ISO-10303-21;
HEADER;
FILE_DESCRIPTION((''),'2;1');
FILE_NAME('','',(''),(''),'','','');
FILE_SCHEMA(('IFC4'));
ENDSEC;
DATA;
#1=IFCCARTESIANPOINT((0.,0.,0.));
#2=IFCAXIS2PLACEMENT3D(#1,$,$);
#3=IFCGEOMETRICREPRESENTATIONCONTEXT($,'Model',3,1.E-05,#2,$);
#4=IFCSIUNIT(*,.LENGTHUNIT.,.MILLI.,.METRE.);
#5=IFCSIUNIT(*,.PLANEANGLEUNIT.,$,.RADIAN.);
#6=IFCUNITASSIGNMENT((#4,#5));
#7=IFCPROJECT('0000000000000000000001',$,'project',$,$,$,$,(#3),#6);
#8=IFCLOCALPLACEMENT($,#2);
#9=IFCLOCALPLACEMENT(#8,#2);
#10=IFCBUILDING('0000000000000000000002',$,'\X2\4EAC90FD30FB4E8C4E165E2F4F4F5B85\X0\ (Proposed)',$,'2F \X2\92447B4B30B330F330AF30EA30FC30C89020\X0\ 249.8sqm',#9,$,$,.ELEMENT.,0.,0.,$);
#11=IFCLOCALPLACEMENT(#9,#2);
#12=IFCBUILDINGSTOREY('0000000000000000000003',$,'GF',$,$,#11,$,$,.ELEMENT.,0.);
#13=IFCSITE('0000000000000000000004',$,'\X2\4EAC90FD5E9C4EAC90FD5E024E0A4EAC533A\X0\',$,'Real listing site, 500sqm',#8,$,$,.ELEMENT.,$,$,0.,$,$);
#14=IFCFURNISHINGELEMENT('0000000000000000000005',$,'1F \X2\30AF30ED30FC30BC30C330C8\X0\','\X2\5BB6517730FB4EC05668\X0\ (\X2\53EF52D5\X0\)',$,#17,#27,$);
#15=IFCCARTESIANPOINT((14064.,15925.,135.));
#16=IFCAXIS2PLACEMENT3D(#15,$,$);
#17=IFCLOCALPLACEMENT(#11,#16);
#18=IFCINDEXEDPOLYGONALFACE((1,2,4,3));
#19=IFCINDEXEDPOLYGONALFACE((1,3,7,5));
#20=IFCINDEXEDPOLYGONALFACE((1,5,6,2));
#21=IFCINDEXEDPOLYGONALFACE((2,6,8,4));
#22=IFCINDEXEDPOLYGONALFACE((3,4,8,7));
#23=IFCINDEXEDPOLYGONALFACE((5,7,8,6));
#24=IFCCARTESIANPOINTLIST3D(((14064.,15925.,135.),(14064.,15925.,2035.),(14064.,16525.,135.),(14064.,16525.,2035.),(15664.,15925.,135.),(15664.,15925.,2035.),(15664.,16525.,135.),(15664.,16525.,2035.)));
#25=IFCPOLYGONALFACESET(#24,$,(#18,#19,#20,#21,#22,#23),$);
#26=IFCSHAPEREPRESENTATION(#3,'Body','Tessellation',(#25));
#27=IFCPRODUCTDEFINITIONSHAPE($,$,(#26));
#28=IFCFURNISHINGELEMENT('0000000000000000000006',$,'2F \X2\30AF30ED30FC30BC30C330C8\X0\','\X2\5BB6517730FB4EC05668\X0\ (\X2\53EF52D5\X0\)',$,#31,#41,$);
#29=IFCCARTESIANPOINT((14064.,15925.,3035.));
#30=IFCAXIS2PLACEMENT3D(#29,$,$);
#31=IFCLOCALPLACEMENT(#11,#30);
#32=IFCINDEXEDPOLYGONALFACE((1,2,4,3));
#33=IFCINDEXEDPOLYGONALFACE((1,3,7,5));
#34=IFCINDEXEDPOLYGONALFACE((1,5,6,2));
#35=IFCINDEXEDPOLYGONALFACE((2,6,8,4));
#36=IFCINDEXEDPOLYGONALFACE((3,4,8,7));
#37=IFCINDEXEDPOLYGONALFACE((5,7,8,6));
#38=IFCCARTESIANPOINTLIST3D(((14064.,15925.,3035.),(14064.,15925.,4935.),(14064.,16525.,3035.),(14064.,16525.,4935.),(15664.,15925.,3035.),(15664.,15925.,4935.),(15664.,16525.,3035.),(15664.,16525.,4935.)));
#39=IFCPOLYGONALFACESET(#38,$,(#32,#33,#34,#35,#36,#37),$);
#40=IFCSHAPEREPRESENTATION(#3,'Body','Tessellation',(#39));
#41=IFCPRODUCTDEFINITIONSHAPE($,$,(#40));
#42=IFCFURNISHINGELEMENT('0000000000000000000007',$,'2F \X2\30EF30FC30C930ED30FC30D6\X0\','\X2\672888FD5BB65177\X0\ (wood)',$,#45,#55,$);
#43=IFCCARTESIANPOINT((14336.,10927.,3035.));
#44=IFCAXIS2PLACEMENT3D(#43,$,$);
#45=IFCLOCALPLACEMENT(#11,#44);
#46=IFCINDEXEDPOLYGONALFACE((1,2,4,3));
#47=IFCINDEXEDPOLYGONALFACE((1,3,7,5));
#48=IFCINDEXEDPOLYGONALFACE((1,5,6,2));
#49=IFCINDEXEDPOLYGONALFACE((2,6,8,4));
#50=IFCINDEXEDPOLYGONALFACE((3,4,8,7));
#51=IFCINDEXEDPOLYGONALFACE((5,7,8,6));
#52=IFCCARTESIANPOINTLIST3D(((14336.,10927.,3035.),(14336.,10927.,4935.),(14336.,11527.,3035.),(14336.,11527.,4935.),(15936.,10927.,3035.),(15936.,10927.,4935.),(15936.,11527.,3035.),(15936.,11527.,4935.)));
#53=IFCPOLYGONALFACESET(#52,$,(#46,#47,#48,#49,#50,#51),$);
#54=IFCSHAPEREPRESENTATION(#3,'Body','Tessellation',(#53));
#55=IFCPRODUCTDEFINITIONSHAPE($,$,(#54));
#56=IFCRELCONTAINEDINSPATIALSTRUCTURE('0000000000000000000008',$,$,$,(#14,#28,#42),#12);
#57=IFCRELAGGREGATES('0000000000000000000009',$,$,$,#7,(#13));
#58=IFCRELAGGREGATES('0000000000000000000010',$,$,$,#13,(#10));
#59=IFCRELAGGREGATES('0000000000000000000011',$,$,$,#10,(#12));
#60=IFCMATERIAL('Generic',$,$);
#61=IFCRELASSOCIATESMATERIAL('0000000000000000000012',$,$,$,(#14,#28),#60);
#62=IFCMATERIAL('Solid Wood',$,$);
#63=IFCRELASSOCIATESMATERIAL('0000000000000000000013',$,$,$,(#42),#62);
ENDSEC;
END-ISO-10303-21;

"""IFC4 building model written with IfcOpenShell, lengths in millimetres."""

from ifc_helpers import new_model, si_unit, frame, frame_2d, origin, place, context, project, spatial, rectangle, extrude, material, element, save


model = new_model("IFC4")

# Units and contexts
model_context = context("Model", 3, precision=1e-05, world=origin())
ifc_project = project(units=[si_unit("LENGTHUNIT", "METRE", prefix="MILLI"), si_unit("PLANEANGLEUNIT", "RADIAN")], contexts=[model_context])

# Site, building, storey
site_placement = place(None, origin())
site = spatial("IfcSite", under=ifc_project, at=site_placement, Name="京都府京都市上京区", ObjectType="Real listing site, 500sqm", CompositionType="ELEMENT", RefElevation=0.0)
building_placement = place(site_placement, origin())
building = spatial("IfcBuilding", under=site, at=building_placement, Name="京都・二世帯住宅 (Proposed)", ObjectType="2F 鉄筋コンクリート造 249.8sqm", CompositionType="ELEMENT", ElevationOfRefHeight=0.0, ElevationOfTerrain=0.0)
storey_placement = place(building_placement, origin())
storey = spatial("IfcBuildingStorey", under=building, at=storey_placement, Name="GF", CompositionType="ELEMENT", Elevation=0.0)

# Shared definitions
ifc_material_1 = material(Name="Solid Wood")

# Shared definitions
ifc_material_2 = material(Name="Generic")

# Furnishing elements
furnishing_1_placement = place(storey_placement, frame((14064.0, 15925.0, 135.0)))
element("IfcFurnishingElement", 1, at=furnishing_1_placement, inside=storey, material=ifc_material_2, Name="1F クローゼット", Description="家具・什器 (可動)", context=model_context, shape_type="SweptSolid", body=[
    extrude(rectangle(XDim=1600.0, YDim=600.0, at=frame_2d((800.0, 300.0))), frame((14064.0, 15925.0, 135.0)), (0.0, 0.0, 1.0), 1900.0),
])
furnishing_2_placement = place(storey_placement, frame((14064.0, 15925.0, 3035.0)))
element("IfcFurnishingElement", 2, at=furnishing_2_placement, inside=storey, material=ifc_material_2, Name="2F クローゼット", Description="家具・什器 (可動)", context=model_context, shape_type="SweptSolid", body=[
    extrude(rectangle(XDim=1600.0, YDim=600.0, at=frame_2d((800.0, 300.0))), frame((14064.0, 15925.0, 3035.0)), (0.0, 0.0, 1.0), 1900.0),
])
furnishing_3_placement = place(storey_placement, frame((14336.0, 10927.0, 3035.0)))
element("IfcFurnishingElement", 3, at=furnishing_3_placement, inside=storey, material=ifc_material_1, Name="2F ワードローブ", Description="木製家具 (wood)", context=model_context, shape_type="SweptSolid", body=[
    extrude(rectangle(XDim=1600.0, YDim=600.0, at=frame_2d((800.0, 300.0))), frame((14336.0, 10927.0, 3035.0)), (0.0, 0.0, 1.0), 1900.0),
])

save(model, "model.ifc")
